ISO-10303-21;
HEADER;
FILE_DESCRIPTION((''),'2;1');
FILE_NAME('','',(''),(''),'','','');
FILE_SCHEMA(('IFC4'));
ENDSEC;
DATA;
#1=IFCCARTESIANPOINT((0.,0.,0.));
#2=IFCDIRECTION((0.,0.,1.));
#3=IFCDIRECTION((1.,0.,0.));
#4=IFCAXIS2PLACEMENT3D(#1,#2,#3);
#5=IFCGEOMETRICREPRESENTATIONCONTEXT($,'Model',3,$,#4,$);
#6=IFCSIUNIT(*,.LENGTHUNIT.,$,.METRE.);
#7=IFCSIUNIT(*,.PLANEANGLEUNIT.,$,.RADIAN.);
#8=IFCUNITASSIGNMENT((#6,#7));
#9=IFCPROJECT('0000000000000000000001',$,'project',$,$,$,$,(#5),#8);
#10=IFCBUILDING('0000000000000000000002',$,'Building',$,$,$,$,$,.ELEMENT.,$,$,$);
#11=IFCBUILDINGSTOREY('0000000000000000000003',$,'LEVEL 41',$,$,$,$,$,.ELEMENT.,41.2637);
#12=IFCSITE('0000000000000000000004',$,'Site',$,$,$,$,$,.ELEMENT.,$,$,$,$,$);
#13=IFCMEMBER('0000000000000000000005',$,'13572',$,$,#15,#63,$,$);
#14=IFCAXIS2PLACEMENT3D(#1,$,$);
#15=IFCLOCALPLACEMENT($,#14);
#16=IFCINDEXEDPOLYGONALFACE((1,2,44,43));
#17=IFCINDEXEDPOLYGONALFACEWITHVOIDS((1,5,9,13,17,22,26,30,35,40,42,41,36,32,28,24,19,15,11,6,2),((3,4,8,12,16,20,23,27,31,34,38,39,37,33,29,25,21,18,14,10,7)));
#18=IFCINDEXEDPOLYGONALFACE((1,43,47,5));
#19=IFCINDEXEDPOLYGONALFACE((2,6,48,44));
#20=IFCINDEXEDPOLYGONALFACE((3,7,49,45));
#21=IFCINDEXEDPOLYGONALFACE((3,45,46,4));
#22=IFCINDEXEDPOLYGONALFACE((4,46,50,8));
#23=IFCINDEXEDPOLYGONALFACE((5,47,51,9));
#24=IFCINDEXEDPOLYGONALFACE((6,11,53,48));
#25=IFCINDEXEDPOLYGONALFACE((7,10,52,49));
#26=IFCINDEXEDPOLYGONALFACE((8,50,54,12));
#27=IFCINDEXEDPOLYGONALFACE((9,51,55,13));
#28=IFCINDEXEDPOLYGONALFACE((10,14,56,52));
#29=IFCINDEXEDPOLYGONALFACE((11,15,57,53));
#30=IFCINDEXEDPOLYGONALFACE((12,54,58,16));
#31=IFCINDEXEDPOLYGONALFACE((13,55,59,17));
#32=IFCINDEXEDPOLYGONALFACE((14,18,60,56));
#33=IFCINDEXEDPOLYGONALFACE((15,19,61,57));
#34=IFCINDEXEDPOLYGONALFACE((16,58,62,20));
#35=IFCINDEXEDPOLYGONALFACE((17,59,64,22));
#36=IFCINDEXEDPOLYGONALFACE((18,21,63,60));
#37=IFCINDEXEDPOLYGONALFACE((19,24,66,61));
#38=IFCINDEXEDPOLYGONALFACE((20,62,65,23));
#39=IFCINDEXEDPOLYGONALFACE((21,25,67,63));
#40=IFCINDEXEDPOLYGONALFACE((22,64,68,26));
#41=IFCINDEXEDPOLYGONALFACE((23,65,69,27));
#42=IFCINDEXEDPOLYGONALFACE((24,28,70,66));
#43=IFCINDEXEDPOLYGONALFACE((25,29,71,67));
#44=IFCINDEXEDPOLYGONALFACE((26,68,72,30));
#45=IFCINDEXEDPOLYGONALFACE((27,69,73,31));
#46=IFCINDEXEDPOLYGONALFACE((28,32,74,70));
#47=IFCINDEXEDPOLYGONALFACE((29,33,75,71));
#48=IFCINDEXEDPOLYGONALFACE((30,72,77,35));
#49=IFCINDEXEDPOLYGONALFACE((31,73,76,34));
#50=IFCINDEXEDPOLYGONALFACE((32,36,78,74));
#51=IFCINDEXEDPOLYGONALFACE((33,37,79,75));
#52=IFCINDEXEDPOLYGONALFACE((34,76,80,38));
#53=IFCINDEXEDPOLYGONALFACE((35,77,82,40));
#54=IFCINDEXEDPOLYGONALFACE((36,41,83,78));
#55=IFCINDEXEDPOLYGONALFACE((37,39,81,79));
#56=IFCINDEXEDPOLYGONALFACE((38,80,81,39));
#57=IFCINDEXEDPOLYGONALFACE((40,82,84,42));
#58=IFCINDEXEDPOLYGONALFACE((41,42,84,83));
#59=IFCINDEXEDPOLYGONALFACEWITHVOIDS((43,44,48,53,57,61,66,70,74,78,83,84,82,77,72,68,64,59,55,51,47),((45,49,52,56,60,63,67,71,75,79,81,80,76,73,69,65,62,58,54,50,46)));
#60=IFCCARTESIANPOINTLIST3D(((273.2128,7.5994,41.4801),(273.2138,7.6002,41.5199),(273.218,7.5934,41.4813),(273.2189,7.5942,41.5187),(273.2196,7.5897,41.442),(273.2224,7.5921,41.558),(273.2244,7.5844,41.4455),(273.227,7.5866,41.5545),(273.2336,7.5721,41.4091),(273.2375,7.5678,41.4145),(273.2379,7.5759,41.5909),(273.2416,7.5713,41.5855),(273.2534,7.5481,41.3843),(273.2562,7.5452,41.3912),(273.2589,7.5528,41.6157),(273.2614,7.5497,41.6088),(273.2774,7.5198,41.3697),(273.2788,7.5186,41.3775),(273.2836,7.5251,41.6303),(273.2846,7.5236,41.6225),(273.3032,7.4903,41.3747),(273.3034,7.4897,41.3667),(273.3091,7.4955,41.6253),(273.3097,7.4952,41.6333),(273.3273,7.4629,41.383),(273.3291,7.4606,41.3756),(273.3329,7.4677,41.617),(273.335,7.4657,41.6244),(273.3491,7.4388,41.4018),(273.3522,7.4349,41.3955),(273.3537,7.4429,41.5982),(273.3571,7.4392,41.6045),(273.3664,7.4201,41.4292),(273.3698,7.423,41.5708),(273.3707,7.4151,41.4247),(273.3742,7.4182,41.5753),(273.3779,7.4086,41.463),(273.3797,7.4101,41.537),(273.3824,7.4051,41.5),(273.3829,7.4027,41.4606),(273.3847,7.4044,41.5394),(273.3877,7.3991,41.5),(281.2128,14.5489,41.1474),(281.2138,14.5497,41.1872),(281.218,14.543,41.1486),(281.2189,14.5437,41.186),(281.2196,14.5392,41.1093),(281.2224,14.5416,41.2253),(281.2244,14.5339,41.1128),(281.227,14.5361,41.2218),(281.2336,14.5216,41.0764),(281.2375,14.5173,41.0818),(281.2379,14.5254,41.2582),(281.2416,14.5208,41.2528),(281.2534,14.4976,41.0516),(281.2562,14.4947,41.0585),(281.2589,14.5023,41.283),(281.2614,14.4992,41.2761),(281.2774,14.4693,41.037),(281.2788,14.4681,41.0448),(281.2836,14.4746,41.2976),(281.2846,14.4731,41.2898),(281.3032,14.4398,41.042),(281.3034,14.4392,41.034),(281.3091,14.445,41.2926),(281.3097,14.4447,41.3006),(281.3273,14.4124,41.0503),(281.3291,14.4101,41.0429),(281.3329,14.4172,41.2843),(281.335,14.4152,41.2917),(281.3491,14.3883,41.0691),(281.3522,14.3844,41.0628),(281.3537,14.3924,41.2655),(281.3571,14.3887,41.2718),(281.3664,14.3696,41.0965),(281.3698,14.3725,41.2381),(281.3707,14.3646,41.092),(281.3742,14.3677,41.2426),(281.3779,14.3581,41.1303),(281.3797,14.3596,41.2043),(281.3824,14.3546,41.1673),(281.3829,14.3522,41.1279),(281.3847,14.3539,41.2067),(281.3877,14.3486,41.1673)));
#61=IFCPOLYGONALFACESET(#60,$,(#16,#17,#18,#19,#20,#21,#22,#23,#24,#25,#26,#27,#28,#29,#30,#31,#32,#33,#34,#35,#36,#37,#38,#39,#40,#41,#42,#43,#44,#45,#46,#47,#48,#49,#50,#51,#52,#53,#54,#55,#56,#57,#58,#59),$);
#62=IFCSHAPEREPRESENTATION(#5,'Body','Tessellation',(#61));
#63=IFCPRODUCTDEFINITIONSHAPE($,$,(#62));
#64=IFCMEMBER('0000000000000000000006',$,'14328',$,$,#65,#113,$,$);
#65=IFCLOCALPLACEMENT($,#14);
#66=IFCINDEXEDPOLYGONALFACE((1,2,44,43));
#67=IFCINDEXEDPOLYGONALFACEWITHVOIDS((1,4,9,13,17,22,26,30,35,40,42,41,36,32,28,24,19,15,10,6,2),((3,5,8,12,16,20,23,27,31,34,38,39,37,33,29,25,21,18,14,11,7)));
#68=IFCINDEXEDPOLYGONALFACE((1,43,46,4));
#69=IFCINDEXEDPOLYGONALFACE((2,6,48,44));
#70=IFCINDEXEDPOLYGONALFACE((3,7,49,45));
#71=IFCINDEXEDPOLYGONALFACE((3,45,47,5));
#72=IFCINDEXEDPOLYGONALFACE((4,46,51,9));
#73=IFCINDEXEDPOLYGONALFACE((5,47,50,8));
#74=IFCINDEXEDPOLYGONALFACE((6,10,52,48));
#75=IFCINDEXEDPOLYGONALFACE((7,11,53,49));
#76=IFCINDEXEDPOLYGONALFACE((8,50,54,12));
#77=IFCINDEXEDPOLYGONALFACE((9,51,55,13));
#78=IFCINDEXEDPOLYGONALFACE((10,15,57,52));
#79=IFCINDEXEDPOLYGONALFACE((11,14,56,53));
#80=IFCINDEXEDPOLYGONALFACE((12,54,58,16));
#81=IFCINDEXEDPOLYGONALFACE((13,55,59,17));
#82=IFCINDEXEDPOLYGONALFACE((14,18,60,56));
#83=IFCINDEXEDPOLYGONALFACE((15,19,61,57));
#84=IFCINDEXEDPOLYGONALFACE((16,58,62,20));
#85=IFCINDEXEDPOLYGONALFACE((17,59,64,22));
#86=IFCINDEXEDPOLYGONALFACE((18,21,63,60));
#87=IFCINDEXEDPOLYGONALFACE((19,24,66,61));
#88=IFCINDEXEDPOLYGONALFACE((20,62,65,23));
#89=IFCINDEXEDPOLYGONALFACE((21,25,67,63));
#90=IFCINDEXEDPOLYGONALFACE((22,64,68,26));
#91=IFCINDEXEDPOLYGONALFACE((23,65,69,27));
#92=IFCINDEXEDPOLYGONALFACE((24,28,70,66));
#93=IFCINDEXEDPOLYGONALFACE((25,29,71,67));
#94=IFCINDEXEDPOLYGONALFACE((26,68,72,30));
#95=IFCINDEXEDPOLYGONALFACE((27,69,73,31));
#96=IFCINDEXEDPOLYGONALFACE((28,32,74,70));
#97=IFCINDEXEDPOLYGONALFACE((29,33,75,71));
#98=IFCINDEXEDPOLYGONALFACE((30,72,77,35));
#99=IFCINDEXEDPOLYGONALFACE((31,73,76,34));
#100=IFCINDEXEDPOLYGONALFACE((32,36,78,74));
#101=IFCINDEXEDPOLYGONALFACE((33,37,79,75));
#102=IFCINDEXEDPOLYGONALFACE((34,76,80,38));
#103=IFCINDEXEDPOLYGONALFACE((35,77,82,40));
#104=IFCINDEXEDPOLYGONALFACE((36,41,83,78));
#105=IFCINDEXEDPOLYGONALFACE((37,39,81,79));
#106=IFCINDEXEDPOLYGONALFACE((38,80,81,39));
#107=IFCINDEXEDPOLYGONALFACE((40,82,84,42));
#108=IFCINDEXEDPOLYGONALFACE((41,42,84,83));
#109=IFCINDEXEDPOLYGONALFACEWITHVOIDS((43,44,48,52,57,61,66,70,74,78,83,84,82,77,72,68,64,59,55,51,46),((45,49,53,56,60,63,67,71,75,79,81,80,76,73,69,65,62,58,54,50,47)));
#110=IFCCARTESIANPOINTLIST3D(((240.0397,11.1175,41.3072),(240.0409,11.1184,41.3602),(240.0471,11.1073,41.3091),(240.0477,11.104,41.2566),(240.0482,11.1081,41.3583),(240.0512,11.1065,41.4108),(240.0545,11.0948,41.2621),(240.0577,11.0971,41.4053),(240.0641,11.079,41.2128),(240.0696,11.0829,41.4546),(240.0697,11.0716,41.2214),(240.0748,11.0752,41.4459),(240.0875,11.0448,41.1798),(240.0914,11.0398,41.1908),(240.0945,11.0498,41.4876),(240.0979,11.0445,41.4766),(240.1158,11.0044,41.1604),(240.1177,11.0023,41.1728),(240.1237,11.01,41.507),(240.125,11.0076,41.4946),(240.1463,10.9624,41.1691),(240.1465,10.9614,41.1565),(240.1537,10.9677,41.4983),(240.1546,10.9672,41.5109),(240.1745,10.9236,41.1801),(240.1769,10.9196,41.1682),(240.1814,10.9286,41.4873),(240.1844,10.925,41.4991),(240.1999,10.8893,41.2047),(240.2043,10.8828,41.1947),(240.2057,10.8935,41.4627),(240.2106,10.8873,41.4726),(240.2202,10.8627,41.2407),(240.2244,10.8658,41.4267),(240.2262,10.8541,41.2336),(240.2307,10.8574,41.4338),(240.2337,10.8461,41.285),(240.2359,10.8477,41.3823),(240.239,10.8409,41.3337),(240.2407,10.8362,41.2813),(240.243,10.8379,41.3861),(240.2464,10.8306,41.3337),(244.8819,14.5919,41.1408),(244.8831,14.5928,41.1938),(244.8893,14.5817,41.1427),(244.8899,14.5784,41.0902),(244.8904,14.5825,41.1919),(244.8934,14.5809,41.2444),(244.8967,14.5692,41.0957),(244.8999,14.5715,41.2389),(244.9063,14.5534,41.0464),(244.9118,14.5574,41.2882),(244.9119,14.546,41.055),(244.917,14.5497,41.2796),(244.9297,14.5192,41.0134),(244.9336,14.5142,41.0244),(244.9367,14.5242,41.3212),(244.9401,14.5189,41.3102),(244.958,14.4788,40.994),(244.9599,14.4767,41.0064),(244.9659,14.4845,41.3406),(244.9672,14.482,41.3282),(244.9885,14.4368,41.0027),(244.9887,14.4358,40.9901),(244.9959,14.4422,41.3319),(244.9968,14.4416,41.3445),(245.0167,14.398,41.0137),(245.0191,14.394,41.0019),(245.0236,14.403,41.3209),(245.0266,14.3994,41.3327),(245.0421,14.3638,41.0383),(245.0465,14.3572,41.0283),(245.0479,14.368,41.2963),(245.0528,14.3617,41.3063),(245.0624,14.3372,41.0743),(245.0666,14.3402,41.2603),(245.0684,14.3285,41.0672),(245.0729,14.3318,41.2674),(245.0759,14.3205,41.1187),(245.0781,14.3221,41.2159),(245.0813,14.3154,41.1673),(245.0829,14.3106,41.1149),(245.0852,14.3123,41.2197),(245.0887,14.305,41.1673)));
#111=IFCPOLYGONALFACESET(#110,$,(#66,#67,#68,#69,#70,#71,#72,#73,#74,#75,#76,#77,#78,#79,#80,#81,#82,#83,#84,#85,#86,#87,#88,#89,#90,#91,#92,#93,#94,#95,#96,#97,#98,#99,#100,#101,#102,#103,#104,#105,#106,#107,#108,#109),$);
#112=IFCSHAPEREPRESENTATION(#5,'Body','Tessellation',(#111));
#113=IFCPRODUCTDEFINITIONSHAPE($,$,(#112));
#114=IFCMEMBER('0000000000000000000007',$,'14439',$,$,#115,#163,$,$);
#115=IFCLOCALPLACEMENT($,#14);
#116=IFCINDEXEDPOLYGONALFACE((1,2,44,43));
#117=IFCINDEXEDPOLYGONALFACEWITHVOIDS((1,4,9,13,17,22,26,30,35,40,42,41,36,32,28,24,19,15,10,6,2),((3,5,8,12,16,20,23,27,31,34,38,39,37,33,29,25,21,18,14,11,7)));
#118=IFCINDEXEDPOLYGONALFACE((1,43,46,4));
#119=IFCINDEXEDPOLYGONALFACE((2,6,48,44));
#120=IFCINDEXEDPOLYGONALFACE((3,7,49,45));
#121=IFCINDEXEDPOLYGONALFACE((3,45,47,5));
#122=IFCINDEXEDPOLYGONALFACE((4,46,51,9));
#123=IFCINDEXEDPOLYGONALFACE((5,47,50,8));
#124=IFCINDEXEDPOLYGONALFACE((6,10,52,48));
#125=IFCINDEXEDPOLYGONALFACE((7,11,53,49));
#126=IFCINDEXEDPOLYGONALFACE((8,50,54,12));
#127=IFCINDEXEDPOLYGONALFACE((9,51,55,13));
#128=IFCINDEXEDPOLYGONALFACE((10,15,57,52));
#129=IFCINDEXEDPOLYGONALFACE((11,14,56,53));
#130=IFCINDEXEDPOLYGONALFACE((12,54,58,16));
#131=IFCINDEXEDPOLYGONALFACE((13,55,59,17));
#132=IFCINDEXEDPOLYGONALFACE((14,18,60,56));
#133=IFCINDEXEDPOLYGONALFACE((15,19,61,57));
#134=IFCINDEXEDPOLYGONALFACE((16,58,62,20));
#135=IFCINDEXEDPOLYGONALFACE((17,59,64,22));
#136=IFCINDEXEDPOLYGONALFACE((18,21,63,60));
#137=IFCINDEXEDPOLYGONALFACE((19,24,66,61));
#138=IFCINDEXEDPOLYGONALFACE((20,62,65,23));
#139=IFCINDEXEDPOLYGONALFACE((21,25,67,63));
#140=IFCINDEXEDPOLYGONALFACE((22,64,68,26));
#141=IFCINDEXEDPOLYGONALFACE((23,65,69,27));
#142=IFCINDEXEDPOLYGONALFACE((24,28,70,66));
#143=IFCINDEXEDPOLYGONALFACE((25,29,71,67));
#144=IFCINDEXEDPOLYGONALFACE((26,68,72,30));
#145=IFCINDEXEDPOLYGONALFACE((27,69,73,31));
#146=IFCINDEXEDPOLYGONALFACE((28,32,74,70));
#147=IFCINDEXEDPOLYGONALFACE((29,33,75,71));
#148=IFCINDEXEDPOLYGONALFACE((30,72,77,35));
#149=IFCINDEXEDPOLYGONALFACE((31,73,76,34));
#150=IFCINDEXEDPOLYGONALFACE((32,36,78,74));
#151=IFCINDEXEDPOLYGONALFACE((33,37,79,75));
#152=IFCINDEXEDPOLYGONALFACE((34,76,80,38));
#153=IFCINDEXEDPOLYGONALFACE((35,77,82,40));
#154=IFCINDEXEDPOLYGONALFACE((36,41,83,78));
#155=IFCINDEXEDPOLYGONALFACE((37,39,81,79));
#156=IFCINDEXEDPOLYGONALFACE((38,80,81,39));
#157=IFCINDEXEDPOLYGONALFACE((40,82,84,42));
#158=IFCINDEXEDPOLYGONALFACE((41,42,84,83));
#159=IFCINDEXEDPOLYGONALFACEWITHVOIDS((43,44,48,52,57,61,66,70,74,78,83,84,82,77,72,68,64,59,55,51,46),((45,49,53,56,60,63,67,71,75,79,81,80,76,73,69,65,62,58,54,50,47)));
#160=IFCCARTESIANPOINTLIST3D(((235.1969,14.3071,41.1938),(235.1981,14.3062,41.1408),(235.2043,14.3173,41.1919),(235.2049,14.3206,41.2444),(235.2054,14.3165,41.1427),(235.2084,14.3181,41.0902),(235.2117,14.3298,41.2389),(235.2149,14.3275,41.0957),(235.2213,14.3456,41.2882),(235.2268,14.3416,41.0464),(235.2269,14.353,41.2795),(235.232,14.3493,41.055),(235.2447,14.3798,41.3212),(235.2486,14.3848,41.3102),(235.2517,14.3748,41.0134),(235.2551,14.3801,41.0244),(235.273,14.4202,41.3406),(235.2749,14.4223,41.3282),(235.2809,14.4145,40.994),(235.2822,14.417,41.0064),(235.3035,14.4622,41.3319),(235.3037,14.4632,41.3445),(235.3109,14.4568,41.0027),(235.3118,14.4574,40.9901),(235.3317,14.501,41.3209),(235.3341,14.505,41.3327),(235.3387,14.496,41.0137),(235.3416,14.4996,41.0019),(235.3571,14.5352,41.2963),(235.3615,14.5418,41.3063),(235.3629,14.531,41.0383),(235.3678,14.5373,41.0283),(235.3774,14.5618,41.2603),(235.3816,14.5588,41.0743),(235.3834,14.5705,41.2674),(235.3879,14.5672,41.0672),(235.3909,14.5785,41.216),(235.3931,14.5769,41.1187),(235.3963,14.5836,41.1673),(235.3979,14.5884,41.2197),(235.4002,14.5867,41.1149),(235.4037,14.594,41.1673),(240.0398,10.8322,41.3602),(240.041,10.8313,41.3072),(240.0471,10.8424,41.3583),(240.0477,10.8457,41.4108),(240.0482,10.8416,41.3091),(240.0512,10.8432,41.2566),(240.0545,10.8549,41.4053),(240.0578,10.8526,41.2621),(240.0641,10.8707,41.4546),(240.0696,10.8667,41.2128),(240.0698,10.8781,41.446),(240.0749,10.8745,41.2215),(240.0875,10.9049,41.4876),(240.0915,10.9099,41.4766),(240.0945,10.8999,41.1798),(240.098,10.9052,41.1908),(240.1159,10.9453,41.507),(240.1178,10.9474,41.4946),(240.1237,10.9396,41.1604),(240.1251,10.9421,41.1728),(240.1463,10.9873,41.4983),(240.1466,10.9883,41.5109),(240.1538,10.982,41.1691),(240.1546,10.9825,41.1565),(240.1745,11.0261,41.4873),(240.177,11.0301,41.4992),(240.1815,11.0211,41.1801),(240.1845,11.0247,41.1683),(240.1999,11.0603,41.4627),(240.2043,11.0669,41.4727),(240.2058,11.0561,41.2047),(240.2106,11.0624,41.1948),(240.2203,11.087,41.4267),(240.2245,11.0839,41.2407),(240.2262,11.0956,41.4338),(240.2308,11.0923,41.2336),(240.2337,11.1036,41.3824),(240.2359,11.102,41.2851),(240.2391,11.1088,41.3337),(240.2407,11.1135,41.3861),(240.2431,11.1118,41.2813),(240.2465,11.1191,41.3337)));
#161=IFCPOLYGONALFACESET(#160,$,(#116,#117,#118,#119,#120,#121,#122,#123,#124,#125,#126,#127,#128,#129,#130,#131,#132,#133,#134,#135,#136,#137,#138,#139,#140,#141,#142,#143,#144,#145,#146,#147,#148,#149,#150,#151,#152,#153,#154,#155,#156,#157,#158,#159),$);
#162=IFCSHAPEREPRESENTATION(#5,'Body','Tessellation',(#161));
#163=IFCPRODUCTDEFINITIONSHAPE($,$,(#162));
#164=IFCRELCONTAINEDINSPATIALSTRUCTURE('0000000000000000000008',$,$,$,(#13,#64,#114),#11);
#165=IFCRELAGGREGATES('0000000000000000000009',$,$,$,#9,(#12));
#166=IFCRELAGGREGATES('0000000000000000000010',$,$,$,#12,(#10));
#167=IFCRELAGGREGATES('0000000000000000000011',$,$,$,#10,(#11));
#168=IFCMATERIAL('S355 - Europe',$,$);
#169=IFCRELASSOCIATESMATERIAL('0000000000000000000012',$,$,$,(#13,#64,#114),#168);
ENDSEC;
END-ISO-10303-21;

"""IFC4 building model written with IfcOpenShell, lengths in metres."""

from ifc_helpers import new_model, si_unit, frame, origin_with_axes, origin_2d_with_axis, place, context, project, spatial, hollow_circle, extrude, material, material_profile, profile_set, profile_usage, element, save


model = new_model("IFC4")

# Units and contexts
model_context = context("Model", 3, world=origin_with_axes())
ifc_project = project(units=[si_unit("LENGTHUNIT", "METRE"), si_unit("PLANEANGLEUNIT", "RADIAN")], contexts=[model_context])

# Site, building, storey
site = spatial("IfcSite", under=ifc_project, Name="Site", CompositionType="ELEMENT")
building = spatial("IfcBuilding", under=site, Name="Building", CompositionType="ELEMENT")
storey = spatial("IfcBuildingStorey", under=building, Name="LEVEL 41", CompositionType="ELEMENT", Elevation=41.2637)

# Shared definitions
ifc_material = material(Name="S355 - Europe")

# Members
ifc_material_profile_1 = material_profile(ifc_material, hollow_circle(Radius=0.1337, WallThickness=0.008, at=origin_2d_with_axis()))
ifc_profile_set_1 = profile_set([ifc_material_profile_1])
ifc_profile_usage_1 = profile_usage(ifc_profile_set_1, cardinal=10)
member_1_placement = place(None, frame((281.3, 14.4495, 41.1673), z_axis=(-0.754562, -0.655478, 0.03138), x_axis=(0.655276, -0.75539, 0.0)))
element("IfcMember", 1, at=member_1_placement, inside=storey, material=ifc_profile_usage_1, Name="13572", context=model_context, shape_type="SweptSolid", body=[
    extrude(hollow_circle(Radius=0.1337, WallThickness=0.008, at=origin_2d_with_axis()), origin_with_axes(), (0.0, 0.0, 1.0), 10.6022),
])
ifc_material_profile_2 = material_profile(ifc_material, hollow_circle(Radius=0.1778, WallThickness=0.0127, at=origin_2d_with_axis()))
ifc_profile_set_2 = profile_set([ifc_material_profile_2])
ifc_profile_usage_2 = profile_usage(ifc_profile_set_2, cardinal=10)
member_2_placement = place(None, frame((244.985, 14.4495, 41.1673), z_axis=(-0.812169, -0.582754, 0.027908), x_axis=(0.582981, -0.812486, 0.0)))
element("IfcMember", 2, at=member_2_placement, inside=storey, material=ifc_profile_usage_2, Name="14328", context=model_context, shape_type="SweptSolid", body=[
    extrude(hollow_circle(Radius=0.1778, WallThickness=0.0127, at=origin_2d_with_axis()), origin_with_axes(), (0.0, 0.0, 1.0), 5.9621),
])
ifc_material_profile_3 = material_profile(ifc_material, hollow_circle(Radius=0.1778, WallThickness=0.0127, at=origin_2d_with_axis()))
ifc_profile_set_3 = profile_set([ifc_material_profile_3])
ifc_profile_usage_3 = profile_usage(ifc_profile_set_3, cardinal=10)
member_3_placement = place(None, frame((235.3, 14.4495, 41.1673), z_axis=(0.812169, -0.582754, 0.027908), x_axis=(0.582077, 0.813134, 0.0)))
element("IfcMember", 3, at=member_3_placement, inside=storey, material=ifc_profile_usage_3, Name="14439", context=model_context, shape_type="SweptSolid", body=[
    extrude(hollow_circle(Radius=0.1778, WallThickness=0.0127, at=origin_2d_with_axis()), origin_with_axes(), (0.0, 0.0, 1.0), 5.9629),
])

save(model, "model.ifc")
